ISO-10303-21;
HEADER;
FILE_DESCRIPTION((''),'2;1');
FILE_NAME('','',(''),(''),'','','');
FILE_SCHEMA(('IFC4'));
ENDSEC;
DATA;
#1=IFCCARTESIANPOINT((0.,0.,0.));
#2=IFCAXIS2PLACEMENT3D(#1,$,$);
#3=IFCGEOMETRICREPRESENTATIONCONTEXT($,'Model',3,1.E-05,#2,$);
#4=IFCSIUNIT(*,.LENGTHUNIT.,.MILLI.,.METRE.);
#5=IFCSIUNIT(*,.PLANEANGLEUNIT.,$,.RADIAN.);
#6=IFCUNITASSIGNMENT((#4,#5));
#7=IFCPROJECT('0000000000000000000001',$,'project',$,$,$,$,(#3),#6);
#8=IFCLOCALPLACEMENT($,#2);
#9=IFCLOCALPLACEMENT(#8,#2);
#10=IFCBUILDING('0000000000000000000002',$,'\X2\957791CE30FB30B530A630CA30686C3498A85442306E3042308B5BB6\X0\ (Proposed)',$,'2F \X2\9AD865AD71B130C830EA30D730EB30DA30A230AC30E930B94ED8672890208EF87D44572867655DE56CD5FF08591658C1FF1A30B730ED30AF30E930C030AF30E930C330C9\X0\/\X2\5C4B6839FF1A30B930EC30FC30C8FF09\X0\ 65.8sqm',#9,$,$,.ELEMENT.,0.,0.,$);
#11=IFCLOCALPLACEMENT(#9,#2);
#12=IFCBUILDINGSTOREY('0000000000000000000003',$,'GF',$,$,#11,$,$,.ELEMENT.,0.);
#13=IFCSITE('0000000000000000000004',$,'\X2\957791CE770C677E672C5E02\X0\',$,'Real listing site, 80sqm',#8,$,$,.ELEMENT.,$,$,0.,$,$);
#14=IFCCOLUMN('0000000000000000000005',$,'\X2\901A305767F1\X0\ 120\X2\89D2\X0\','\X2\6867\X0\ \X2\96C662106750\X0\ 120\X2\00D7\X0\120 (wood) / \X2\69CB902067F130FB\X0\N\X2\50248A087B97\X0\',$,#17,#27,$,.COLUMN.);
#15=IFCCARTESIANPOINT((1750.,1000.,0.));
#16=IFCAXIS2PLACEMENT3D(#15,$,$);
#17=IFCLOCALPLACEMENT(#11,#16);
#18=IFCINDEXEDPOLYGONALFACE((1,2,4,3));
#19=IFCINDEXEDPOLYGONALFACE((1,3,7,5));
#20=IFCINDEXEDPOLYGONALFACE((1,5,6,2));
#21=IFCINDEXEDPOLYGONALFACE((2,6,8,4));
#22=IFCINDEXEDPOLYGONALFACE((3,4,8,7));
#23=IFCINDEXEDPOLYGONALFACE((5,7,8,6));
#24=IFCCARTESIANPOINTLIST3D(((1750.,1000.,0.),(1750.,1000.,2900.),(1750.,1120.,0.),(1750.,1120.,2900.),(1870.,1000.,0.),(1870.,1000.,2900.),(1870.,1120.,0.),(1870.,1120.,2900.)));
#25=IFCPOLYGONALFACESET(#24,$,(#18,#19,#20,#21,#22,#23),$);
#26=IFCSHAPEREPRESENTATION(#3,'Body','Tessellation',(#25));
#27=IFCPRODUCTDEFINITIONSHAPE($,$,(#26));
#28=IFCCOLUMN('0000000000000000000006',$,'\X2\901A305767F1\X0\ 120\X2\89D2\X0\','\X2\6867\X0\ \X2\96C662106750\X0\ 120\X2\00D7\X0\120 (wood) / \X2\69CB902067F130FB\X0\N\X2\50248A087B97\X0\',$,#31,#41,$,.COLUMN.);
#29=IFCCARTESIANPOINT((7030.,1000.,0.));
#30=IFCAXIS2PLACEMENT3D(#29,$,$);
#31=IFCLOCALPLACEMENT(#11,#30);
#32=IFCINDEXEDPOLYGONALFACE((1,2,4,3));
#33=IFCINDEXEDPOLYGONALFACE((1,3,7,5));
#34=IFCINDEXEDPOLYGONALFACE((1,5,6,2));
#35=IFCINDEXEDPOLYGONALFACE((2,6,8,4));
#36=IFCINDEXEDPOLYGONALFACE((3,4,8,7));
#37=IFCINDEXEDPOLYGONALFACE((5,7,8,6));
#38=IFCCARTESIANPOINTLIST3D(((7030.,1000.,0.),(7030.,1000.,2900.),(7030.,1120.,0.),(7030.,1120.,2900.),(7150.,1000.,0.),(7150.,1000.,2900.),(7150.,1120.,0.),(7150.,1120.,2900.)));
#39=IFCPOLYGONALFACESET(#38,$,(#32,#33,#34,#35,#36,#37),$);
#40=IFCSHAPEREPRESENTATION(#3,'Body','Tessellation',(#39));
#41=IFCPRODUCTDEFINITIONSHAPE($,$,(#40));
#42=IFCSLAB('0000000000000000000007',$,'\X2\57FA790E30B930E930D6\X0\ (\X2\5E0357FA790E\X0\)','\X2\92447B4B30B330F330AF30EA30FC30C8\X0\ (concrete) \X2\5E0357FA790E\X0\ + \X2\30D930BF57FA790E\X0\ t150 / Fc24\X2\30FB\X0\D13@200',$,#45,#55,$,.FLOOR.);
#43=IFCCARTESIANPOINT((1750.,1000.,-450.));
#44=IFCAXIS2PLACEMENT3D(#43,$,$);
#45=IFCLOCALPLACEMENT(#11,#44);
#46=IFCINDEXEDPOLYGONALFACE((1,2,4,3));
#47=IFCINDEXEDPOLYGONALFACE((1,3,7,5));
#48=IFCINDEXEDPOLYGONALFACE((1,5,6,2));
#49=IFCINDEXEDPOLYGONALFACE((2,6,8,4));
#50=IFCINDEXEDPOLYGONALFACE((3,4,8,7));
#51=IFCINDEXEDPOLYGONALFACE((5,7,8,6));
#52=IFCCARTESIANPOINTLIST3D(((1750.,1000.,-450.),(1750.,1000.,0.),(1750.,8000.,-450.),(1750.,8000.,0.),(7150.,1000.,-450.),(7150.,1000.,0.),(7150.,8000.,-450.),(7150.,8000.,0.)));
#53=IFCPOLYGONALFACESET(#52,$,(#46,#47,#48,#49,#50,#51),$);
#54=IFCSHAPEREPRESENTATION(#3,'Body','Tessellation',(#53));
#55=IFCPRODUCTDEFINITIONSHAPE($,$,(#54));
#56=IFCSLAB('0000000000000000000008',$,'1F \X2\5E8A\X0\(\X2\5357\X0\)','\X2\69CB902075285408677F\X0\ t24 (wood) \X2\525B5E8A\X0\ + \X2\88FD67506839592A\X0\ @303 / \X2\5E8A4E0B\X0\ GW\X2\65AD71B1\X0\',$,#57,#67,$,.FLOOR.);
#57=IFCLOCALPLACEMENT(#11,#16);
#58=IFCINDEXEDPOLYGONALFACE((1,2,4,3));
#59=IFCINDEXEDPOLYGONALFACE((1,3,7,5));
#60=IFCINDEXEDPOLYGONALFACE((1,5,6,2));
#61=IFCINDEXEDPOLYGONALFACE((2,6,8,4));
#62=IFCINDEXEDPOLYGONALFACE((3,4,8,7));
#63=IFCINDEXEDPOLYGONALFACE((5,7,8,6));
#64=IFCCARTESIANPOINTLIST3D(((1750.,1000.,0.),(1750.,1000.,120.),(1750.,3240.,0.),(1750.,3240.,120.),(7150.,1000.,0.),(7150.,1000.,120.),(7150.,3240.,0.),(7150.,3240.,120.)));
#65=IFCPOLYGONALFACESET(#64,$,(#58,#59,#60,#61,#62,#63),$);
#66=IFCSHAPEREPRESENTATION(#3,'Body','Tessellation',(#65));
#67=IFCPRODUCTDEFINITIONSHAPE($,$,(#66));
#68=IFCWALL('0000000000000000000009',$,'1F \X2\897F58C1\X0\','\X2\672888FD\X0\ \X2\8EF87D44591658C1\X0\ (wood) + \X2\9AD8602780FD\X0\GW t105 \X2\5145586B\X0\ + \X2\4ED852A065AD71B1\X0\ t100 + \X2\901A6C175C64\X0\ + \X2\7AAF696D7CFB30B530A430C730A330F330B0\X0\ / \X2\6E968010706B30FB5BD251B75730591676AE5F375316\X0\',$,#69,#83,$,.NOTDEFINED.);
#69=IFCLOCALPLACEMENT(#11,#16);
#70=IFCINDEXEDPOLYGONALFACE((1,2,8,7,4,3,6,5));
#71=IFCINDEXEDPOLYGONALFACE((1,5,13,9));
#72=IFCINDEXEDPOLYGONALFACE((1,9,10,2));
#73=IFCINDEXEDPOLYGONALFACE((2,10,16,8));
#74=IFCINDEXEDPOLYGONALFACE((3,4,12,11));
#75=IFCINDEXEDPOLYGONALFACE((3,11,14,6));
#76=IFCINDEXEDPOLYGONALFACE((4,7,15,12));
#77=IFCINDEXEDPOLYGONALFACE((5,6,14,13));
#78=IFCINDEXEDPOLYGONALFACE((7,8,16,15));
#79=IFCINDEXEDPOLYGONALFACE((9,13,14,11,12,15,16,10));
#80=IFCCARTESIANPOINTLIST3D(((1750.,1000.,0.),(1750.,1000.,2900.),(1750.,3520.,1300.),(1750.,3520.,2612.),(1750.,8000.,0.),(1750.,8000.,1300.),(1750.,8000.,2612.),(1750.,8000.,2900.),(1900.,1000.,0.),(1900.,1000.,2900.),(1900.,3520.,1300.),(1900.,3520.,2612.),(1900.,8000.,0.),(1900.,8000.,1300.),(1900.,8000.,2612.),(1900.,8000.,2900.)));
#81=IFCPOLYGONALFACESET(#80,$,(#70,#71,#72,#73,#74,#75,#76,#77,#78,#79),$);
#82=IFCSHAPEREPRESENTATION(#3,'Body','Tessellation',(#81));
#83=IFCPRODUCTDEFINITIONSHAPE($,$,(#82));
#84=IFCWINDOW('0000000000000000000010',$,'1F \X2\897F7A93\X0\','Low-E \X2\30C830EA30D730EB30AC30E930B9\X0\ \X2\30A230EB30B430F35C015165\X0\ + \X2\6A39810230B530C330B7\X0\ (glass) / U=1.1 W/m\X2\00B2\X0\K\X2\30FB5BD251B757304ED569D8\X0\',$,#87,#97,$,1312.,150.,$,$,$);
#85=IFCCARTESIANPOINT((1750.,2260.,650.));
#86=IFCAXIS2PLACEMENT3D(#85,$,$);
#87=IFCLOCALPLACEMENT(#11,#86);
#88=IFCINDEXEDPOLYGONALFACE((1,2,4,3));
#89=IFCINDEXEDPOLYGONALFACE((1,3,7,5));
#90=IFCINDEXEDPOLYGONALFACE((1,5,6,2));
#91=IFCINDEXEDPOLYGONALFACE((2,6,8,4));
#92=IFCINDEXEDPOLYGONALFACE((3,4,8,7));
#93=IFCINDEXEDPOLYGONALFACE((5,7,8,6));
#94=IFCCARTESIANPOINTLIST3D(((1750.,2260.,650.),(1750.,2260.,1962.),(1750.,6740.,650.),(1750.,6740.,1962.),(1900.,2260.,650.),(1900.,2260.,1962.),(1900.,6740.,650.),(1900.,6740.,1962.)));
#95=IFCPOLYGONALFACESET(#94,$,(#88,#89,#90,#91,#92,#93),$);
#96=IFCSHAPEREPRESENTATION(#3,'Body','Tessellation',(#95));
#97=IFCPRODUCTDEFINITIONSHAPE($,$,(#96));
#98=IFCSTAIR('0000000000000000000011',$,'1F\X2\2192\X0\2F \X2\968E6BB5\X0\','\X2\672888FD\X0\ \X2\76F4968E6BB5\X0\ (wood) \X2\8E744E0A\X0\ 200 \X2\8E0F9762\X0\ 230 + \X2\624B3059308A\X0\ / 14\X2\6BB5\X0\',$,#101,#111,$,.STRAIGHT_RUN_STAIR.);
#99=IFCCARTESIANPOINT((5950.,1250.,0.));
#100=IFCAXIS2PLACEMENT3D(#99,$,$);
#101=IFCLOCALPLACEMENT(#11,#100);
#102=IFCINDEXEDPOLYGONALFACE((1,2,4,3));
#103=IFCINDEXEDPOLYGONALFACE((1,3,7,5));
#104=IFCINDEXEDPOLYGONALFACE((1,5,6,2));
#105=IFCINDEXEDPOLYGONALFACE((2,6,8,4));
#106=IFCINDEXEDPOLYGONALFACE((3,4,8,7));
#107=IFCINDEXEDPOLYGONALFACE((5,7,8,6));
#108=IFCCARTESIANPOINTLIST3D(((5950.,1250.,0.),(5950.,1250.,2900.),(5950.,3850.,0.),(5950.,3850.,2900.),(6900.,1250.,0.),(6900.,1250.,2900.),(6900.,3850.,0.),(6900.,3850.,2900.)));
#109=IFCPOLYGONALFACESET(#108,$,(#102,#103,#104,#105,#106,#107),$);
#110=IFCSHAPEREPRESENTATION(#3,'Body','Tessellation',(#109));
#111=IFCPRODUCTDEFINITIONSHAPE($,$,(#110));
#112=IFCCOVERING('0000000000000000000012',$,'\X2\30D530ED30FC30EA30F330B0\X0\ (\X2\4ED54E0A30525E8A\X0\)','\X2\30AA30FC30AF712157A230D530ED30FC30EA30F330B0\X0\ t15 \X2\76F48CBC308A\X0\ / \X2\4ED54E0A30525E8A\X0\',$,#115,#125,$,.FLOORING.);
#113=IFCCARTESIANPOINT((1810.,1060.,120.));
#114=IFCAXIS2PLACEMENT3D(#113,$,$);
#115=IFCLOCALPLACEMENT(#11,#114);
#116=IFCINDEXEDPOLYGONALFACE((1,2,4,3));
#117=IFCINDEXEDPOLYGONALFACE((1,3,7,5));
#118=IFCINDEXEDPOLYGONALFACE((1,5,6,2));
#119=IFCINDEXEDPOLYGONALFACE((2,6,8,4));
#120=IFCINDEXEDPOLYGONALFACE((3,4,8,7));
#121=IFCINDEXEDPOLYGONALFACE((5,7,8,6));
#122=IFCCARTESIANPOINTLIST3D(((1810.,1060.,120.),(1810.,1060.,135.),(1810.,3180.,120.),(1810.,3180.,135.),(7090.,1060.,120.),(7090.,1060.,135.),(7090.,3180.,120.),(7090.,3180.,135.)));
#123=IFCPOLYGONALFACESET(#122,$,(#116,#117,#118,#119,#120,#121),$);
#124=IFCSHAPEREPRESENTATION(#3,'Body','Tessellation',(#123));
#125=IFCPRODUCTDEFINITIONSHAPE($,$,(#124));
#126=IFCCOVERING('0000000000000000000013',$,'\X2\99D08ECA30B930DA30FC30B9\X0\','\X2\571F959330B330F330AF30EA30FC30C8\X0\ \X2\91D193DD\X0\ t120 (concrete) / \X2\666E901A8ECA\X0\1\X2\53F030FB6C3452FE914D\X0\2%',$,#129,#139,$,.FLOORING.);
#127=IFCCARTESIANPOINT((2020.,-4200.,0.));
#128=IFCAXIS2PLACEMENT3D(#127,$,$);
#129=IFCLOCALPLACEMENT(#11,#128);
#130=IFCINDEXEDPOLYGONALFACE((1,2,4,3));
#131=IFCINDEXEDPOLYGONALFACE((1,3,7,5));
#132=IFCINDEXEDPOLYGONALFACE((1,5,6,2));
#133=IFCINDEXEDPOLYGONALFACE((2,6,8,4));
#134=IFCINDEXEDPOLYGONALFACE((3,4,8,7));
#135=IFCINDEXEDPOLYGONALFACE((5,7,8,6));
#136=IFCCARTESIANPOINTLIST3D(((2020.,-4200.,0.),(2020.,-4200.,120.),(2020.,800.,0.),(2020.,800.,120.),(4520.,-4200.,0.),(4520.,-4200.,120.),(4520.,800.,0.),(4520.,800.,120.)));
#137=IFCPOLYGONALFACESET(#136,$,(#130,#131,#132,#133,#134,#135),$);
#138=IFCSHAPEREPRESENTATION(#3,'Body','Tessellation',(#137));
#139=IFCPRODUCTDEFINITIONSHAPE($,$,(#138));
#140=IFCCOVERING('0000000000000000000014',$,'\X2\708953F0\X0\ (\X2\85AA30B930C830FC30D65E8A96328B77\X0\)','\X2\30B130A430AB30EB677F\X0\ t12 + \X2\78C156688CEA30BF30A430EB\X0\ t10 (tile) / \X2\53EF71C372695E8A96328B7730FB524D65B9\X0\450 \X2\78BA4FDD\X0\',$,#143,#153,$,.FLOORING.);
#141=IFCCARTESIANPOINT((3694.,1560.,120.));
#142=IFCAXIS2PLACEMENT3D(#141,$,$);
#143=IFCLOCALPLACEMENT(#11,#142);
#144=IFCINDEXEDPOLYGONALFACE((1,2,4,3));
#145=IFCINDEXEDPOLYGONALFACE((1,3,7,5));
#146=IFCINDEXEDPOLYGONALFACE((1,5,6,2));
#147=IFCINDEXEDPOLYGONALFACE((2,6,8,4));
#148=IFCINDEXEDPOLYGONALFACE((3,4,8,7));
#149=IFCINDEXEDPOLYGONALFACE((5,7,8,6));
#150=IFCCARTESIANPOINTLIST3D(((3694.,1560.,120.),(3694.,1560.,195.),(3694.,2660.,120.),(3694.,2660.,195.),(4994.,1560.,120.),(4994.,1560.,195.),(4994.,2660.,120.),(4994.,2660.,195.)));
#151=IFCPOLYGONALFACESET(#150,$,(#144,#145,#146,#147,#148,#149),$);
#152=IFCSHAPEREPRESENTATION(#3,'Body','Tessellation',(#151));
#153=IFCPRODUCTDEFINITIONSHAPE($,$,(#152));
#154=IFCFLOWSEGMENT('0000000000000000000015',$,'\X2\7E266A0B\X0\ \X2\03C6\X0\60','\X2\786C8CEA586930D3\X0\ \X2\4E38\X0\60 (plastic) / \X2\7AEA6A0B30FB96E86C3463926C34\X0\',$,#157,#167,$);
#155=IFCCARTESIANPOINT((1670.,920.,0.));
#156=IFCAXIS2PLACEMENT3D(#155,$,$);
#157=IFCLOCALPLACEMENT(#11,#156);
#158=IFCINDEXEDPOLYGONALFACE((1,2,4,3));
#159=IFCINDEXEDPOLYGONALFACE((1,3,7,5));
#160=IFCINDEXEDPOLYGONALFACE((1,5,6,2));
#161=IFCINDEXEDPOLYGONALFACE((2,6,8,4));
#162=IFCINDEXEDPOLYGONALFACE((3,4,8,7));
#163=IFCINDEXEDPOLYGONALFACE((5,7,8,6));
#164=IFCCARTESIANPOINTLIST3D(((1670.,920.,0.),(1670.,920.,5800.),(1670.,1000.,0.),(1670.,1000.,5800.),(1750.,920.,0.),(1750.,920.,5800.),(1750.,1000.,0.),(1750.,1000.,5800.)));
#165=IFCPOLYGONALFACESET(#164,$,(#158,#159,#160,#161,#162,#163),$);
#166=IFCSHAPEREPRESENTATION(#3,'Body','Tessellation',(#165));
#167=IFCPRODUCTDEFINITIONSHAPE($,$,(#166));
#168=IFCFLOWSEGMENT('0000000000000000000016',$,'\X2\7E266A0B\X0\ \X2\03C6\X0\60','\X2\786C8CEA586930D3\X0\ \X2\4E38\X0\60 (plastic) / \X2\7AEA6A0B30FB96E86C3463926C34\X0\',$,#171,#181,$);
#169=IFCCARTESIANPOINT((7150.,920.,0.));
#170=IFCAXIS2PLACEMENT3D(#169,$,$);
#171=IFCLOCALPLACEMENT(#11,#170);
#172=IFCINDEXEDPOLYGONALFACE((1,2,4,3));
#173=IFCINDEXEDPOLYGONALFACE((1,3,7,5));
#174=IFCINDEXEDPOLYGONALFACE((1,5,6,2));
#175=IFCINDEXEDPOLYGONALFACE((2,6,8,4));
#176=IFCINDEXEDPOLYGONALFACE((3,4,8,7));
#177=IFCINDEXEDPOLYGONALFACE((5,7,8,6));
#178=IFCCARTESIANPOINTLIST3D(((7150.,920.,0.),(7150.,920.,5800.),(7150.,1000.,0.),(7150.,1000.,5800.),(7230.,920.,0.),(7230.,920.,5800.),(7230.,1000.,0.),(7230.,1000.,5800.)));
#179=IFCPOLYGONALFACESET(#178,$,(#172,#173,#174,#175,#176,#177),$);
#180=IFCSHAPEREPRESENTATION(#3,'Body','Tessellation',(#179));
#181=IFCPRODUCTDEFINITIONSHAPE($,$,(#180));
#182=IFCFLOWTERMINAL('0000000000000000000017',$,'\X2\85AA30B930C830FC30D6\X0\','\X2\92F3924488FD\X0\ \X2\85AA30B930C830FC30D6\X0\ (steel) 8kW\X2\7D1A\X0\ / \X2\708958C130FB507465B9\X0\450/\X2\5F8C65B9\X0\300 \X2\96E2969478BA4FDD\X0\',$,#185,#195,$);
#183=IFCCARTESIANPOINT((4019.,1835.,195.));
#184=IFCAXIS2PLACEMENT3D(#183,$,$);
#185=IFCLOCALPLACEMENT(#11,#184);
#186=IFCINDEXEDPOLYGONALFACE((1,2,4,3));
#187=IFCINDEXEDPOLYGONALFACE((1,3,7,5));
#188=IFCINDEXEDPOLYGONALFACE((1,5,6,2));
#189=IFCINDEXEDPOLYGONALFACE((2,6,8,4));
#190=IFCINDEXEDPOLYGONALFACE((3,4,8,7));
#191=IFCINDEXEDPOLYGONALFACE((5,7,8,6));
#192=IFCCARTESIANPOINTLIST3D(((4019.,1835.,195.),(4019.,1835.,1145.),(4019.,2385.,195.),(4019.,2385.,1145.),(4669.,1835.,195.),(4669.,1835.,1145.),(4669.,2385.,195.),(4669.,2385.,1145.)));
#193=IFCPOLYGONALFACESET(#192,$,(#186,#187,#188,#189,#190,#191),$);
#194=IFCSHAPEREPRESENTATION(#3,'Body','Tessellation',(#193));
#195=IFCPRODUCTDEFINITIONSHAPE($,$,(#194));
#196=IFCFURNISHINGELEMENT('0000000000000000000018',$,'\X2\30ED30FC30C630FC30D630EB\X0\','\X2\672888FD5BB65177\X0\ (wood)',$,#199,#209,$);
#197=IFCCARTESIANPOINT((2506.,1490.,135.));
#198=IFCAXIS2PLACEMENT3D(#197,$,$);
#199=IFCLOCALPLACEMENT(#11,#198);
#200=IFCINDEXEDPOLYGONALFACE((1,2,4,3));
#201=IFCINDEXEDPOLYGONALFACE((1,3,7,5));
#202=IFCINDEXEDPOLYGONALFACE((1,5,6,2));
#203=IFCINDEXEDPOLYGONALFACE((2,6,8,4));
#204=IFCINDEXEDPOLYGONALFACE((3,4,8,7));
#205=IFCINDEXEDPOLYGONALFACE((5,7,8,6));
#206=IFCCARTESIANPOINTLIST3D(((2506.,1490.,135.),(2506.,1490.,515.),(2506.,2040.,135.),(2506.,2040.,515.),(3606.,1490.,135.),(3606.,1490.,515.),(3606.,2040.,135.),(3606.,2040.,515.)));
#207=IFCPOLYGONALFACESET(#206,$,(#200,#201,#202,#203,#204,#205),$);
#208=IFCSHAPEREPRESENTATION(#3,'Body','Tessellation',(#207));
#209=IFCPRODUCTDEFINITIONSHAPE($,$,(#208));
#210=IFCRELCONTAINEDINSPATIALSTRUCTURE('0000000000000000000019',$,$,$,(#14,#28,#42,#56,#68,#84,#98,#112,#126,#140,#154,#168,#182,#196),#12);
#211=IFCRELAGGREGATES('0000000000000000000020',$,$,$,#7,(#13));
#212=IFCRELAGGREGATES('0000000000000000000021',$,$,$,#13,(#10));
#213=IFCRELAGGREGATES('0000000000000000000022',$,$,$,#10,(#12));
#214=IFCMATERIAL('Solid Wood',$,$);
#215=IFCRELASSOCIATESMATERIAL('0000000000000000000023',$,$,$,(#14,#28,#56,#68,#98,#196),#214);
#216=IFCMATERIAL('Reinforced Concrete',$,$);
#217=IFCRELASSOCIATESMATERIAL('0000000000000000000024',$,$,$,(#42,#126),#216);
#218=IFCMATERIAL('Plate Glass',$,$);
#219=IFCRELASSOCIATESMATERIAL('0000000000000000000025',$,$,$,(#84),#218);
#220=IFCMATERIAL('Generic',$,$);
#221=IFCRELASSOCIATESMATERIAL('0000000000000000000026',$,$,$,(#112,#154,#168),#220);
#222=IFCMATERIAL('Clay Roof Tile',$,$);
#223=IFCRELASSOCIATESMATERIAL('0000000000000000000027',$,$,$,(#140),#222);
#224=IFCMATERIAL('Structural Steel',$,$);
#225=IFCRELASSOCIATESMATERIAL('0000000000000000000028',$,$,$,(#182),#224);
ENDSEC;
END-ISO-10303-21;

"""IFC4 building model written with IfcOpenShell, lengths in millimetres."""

from ifc_helpers import new_model, si_unit, frame, frame_2d, origin, place, context, project, spatial, rectangle, extrude, material, element, fill, save


model = new_model("IFC4")

# Units and contexts
model_context = context("Model", 3, precision=1e-05, world=origin())
ifc_project = project(units=[si_unit("LENGTHUNIT", "METRE", prefix="MILLI"), si_unit("PLANEANGLEUNIT", "RADIAN")], contexts=[model_context])

# Site, building, storey
site_placement = place(None, origin())
site = spatial("IfcSite", under=ifc_project, at=site_placement, Name="長野県松本市", ObjectType="Real listing site, 80sqm", CompositionType="ELEMENT", RefElevation=0.0)
building_placement = place(site_placement, origin())
building = spatial("IfcBuilding", under=site, at=building_placement, Name="長野・サウナと水風呂のある家 (Proposed)", ObjectType="2F 高断熱トリプルペアガラス付木造軸組在来工法（外壁：シロクラダクラッド/屋根：スレート） 65.8sqm", CompositionType="ELEMENT", ElevationOfRefHeight=0.0, ElevationOfTerrain=0.0)
storey_placement = place(building_placement, origin())
storey = spatial("IfcBuildingStorey", under=building, at=storey_placement, Name="GF", CompositionType="ELEMENT", Elevation=0.0)

# Columns
ifc_material_1 = material(Name="Solid Wood")
column_1_placement = place(storey_placement, frame((1750.0, 1000.0, 0.0)))
element("IfcColumn", 1, at=column_1_placement, inside=storey, material=ifc_material_1, Name="通し柱 120角", Description="桧 集成材 120×120 (wood) / 構造柱・N値計算", PredefinedType="COLUMN", context=model_context, shape_type="SweptSolid", body=[
    extrude(rectangle(XDim=120.0, YDim=120.0, at=frame_2d((60.0, 60.0))), frame((1750.0, 1000.0, 0.0)), (0.0, 0.0, 1.0), 2900.0),
])
column_2_placement = place(storey_placement, frame((7030.0, 1000.0, 0.0)))
element("IfcColumn", 2, at=column_2_placement, inside=storey, material=ifc_material_1, Name="通し柱 120角", Description="桧 集成材 120×120 (wood) / 構造柱・N値計算", PredefinedType="COLUMN", context=model_context, shape_type="SweptSolid", body=[
    extrude(rectangle(XDim=120.0, YDim=120.0, at=frame_2d((60.0, 60.0))), frame((7030.0, 1000.0, 0.0)), (0.0, 0.0, 1.0), 2900.0),
])

# Slabs
ifc_material_2 = material(Name="Reinforced Concrete")
slab_1_placement = place(storey_placement, frame((1750.0, 1000.0, -450.0)))
element("IfcSlab", 3, at=slab_1_placement, inside=storey, material=ifc_material_2, Name="基礎スラブ (布基礎)", Description="鉄筋コンクリート (concrete) 布基礎 + ベタ基礎 t150 / Fc24・D13@200", PredefinedType="FLOOR", context=model_context, shape_type="SweptSolid", body=[
    extrude(rectangle(XDim=5400.0, YDim=7000.0, at=frame_2d((2700.0, 3500.0))), frame((1750.0, 1000.0, -450.0)), (0.0, 0.0, 1.0), 450.0),
])
slab_2_placement = place(storey_placement, frame((1750.0, 1000.0, 0.0)))
element("IfcSlab", 4, at=slab_2_placement, inside=storey, material=ifc_material_1, Name="1F 床(南)", Description="構造用合板 t24 (wood) 剛床 + 製材根太 @303 / 床下 GW断熱", PredefinedType="FLOOR", context=model_context, shape_type="SweptSolid", body=[
    extrude(rectangle(XDim=5400.0, YDim=2240.0, at=frame_2d((2700.0, 1120.0))), frame((1750.0, 1000.0, 0.0)), (0.0, 0.0, 1.0), 120.0),
])

# Shared definitions
ifc_material_3 = material(Name="Plate Glass")

# Wall, opening, window
wall_1_placement = place(storey_placement, frame((1750.0, 1000.0, 0.0)))
wall_1 = element("IfcWall", 5, at=wall_1_placement, inside=storey, material=ifc_material_1, Name="1F 西壁", Description="木製 軸組外壁 (wood) + 高性能GW t105 充填 + 付加断熱 t100 + 通気層 + 窯業系サイディング / 準耐火・寒冷地外皮強化", PredefinedType="NOTDEFINED", context=model_context, shape_type="SweptSolid", body=[
    extrude(rectangle(XDim=150.0, YDim=7000.0, at=frame_2d((75.0, 3500.0))), frame((1750.0, 1000.0, 0.0)), (0.0, 0.0, 1.0), 2900.0),
])
opening_1_placement = place(storey_placement, frame((1750.0, 2260.0, 650.0)))
opening_1 = element("IfcOpeningElement", 6, at=opening_1_placement, cuts=wall_1, PredefinedType="NOTDEFINED", context=model_context, shape_type="SweptSolid", body=[
    extrude(rectangle(XDim=150.0, YDim=4480.0, at=frame_2d((75.0, 2240.0))), frame((1750.0, 2260.0, 650.0)), (0.0, 0.0, 1.0), 1312.0),
])
window_1_placement = place(storey_placement, frame((1750.0, 2260.0, 650.0)))
window_1 = element("IfcWindow", 7, at=window_1_placement, inside=storey, material=ifc_material_3, Name="1F 西窓", Description="Low-E トリプルガラス アルゴン封入 + 樹脂サッシ (glass) / U=1.1 W/m²K・寒冷地仕様", OverallHeight=1312.0, OverallWidth=150.0, context=model_context, shape_type="SweptSolid", body=[
    extrude(rectangle(XDim=150.0, YDim=4480.0, at=frame_2d((75.0, 2240.0))), frame((1750.0, 2260.0, 650.0)), (0.0, 0.0, 1.0), 1312.0),
])
fill(opening_1, window_1)

# Stair
stair_placement = place(storey_placement, frame((5950.0, 1250.0, 0.0)))
element("IfcStair", 8, at=stair_placement, inside=storey, material=ifc_material_1, Name="1F→2F 階段", Description="木製 直階段 (wood) 蹴上 200 踏面 230 + 手すり / 14段", PredefinedType="STRAIGHT_RUN_STAIR", context=model_context, shape_type="SweptSolid", body=[
    extrude(rectangle(XDim=950.0, YDim=2600.0, at=frame_2d((475.0, 1300.0))), frame((5950.0, 1250.0, 0.0)), (0.0, 0.0, 1.0), 2900.0),
])

# Coverings
ifc_material_4 = material(Name="Generic")
covering_1_placement = place(storey_placement, frame((1810.0, 1060.0, 120.0)))
element("IfcCovering", 9, at=covering_1_placement, inside=storey, material=ifc_material_4, Name="フローリング (仕上げ床)", Description="オーク無垢フローリング t15 直貼り / 仕上げ床", PredefinedType="FLOORING", context=model_context, shape_type="SweptSolid", body=[
    extrude(rectangle(XDim=5280.0, YDim=2120.0, at=frame_2d((2640.0, 1060.0))), frame((1810.0, 1060.0, 120.0)), (0.0, 0.0, 1.0), 15.0),
])
covering_2_placement = place(storey_placement, frame((2020.0, -4200.0, 0.0)))
element("IfcCovering", 10, at=covering_2_placement, inside=storey, material=ifc_material_2, Name="駐車スペース", Description="土間コンクリート 金鏝 t120 (concrete) / 普通車1台・水勾配2%", PredefinedType="FLOORING", context=model_context, shape_type="SweptSolid", body=[
    extrude(rectangle(XDim=2500.0, YDim=5000.0, at=frame_2d((1250.0, 2500.0))), frame((2020.0, -4200.0, 0.0)), (0.0, 0.0, 1.0), 120.0),
])
ifc_material_5 = material(Name="Clay Roof Tile")
covering_3_placement = place(storey_placement, frame((3694.0, 1560.0, 120.0)))
element("IfcCovering", 11, at=covering_3_placement, inside=storey, material=ifc_material_5, Name="炉台 (薪ストーブ床防護)", Description="ケイカル板 t12 + 磁器質タイル t10 (tile) / 可燃物床防護・前方450 確保", PredefinedType="FLOORING", context=model_context, shape_type="SweptSolid", body=[
    extrude(rectangle(XDim=1300.0, YDim=1100.0, at=frame_2d((650.0, 550.0))), frame((3694.0, 1560.0, 120.0)), (0.0, 0.0, 1.0), 75.0),
])

# Flow segments
flow_segment_1_placement = place(storey_placement, frame((1670.0, 920.0, 0.0)))
element("IfcFlowSegment", 12, at=flow_segment_1_placement, inside=storey, material=ifc_material_4, Name="縦樋 φ60", Description="硬質塩ビ 丸60 (plastic) / 竪樋・雨水排水", context=model_context, shape_type="SweptSolid", body=[
    extrude(rectangle(XDim=80.0, YDim=80.0, at=frame_2d((40.0, 40.0))), frame((1670.0, 920.0, 0.0)), (0.0, 0.0, 1.0), 5800.0),
])
flow_segment_2_placement = place(storey_placement, frame((7150.0, 920.0, 0.0)))
element("IfcFlowSegment", 13, at=flow_segment_2_placement, inside=storey, material=ifc_material_4, Name="縦樋 φ60", Description="硬質塩ビ 丸60 (plastic) / 竪樋・雨水排水", context=model_context, shape_type="SweptSolid", body=[
    extrude(rectangle(XDim=80.0, YDim=80.0, at=frame_2d((40.0, 40.0))), frame((7150.0, 920.0, 0.0)), (0.0, 0.0, 1.0), 5800.0),
])

# Flow terminal
ifc_material_6 = material(Name="Structural Steel")
flow_terminal_placement = place(storey_placement, frame((4019.0, 1835.0, 195.0)))
element("IfcFlowTerminal", 14, at=flow_terminal_placement, inside=storey, material=ifc_material_6, Name="薪ストーブ", Description="鋳鉄製 薪ストーブ (steel) 8kW級 / 炉壁・側方450/後方300 離隔確保", context=model_context, shape_type="SweptSolid", body=[
    extrude(rectangle(XDim=650.0, YDim=550.0, at=frame_2d((325.0, 275.0))), frame((4019.0, 1835.0, 195.0)), (0.0, 0.0, 1.0), 950.0),
])

# Furnishing element
furnishing_1_placement = place(storey_placement, frame((2506.0, 1490.0, 135.0)))
element("IfcFurnishingElement", 15, at=furnishing_1_placement, inside=storey, material=ifc_material_1, Name="ローテーブル", Description="木製家具 (wood)", context=model_context, shape_type="SweptSolid", body=[
    extrude(rectangle(XDim=1100.0, YDim=550.0, at=frame_2d((550.0, 275.0))), frame((2506.0, 1490.0, 135.0)), (0.0, 0.0, 1.0), 380.0),
])

save(model, "model.ifc")
